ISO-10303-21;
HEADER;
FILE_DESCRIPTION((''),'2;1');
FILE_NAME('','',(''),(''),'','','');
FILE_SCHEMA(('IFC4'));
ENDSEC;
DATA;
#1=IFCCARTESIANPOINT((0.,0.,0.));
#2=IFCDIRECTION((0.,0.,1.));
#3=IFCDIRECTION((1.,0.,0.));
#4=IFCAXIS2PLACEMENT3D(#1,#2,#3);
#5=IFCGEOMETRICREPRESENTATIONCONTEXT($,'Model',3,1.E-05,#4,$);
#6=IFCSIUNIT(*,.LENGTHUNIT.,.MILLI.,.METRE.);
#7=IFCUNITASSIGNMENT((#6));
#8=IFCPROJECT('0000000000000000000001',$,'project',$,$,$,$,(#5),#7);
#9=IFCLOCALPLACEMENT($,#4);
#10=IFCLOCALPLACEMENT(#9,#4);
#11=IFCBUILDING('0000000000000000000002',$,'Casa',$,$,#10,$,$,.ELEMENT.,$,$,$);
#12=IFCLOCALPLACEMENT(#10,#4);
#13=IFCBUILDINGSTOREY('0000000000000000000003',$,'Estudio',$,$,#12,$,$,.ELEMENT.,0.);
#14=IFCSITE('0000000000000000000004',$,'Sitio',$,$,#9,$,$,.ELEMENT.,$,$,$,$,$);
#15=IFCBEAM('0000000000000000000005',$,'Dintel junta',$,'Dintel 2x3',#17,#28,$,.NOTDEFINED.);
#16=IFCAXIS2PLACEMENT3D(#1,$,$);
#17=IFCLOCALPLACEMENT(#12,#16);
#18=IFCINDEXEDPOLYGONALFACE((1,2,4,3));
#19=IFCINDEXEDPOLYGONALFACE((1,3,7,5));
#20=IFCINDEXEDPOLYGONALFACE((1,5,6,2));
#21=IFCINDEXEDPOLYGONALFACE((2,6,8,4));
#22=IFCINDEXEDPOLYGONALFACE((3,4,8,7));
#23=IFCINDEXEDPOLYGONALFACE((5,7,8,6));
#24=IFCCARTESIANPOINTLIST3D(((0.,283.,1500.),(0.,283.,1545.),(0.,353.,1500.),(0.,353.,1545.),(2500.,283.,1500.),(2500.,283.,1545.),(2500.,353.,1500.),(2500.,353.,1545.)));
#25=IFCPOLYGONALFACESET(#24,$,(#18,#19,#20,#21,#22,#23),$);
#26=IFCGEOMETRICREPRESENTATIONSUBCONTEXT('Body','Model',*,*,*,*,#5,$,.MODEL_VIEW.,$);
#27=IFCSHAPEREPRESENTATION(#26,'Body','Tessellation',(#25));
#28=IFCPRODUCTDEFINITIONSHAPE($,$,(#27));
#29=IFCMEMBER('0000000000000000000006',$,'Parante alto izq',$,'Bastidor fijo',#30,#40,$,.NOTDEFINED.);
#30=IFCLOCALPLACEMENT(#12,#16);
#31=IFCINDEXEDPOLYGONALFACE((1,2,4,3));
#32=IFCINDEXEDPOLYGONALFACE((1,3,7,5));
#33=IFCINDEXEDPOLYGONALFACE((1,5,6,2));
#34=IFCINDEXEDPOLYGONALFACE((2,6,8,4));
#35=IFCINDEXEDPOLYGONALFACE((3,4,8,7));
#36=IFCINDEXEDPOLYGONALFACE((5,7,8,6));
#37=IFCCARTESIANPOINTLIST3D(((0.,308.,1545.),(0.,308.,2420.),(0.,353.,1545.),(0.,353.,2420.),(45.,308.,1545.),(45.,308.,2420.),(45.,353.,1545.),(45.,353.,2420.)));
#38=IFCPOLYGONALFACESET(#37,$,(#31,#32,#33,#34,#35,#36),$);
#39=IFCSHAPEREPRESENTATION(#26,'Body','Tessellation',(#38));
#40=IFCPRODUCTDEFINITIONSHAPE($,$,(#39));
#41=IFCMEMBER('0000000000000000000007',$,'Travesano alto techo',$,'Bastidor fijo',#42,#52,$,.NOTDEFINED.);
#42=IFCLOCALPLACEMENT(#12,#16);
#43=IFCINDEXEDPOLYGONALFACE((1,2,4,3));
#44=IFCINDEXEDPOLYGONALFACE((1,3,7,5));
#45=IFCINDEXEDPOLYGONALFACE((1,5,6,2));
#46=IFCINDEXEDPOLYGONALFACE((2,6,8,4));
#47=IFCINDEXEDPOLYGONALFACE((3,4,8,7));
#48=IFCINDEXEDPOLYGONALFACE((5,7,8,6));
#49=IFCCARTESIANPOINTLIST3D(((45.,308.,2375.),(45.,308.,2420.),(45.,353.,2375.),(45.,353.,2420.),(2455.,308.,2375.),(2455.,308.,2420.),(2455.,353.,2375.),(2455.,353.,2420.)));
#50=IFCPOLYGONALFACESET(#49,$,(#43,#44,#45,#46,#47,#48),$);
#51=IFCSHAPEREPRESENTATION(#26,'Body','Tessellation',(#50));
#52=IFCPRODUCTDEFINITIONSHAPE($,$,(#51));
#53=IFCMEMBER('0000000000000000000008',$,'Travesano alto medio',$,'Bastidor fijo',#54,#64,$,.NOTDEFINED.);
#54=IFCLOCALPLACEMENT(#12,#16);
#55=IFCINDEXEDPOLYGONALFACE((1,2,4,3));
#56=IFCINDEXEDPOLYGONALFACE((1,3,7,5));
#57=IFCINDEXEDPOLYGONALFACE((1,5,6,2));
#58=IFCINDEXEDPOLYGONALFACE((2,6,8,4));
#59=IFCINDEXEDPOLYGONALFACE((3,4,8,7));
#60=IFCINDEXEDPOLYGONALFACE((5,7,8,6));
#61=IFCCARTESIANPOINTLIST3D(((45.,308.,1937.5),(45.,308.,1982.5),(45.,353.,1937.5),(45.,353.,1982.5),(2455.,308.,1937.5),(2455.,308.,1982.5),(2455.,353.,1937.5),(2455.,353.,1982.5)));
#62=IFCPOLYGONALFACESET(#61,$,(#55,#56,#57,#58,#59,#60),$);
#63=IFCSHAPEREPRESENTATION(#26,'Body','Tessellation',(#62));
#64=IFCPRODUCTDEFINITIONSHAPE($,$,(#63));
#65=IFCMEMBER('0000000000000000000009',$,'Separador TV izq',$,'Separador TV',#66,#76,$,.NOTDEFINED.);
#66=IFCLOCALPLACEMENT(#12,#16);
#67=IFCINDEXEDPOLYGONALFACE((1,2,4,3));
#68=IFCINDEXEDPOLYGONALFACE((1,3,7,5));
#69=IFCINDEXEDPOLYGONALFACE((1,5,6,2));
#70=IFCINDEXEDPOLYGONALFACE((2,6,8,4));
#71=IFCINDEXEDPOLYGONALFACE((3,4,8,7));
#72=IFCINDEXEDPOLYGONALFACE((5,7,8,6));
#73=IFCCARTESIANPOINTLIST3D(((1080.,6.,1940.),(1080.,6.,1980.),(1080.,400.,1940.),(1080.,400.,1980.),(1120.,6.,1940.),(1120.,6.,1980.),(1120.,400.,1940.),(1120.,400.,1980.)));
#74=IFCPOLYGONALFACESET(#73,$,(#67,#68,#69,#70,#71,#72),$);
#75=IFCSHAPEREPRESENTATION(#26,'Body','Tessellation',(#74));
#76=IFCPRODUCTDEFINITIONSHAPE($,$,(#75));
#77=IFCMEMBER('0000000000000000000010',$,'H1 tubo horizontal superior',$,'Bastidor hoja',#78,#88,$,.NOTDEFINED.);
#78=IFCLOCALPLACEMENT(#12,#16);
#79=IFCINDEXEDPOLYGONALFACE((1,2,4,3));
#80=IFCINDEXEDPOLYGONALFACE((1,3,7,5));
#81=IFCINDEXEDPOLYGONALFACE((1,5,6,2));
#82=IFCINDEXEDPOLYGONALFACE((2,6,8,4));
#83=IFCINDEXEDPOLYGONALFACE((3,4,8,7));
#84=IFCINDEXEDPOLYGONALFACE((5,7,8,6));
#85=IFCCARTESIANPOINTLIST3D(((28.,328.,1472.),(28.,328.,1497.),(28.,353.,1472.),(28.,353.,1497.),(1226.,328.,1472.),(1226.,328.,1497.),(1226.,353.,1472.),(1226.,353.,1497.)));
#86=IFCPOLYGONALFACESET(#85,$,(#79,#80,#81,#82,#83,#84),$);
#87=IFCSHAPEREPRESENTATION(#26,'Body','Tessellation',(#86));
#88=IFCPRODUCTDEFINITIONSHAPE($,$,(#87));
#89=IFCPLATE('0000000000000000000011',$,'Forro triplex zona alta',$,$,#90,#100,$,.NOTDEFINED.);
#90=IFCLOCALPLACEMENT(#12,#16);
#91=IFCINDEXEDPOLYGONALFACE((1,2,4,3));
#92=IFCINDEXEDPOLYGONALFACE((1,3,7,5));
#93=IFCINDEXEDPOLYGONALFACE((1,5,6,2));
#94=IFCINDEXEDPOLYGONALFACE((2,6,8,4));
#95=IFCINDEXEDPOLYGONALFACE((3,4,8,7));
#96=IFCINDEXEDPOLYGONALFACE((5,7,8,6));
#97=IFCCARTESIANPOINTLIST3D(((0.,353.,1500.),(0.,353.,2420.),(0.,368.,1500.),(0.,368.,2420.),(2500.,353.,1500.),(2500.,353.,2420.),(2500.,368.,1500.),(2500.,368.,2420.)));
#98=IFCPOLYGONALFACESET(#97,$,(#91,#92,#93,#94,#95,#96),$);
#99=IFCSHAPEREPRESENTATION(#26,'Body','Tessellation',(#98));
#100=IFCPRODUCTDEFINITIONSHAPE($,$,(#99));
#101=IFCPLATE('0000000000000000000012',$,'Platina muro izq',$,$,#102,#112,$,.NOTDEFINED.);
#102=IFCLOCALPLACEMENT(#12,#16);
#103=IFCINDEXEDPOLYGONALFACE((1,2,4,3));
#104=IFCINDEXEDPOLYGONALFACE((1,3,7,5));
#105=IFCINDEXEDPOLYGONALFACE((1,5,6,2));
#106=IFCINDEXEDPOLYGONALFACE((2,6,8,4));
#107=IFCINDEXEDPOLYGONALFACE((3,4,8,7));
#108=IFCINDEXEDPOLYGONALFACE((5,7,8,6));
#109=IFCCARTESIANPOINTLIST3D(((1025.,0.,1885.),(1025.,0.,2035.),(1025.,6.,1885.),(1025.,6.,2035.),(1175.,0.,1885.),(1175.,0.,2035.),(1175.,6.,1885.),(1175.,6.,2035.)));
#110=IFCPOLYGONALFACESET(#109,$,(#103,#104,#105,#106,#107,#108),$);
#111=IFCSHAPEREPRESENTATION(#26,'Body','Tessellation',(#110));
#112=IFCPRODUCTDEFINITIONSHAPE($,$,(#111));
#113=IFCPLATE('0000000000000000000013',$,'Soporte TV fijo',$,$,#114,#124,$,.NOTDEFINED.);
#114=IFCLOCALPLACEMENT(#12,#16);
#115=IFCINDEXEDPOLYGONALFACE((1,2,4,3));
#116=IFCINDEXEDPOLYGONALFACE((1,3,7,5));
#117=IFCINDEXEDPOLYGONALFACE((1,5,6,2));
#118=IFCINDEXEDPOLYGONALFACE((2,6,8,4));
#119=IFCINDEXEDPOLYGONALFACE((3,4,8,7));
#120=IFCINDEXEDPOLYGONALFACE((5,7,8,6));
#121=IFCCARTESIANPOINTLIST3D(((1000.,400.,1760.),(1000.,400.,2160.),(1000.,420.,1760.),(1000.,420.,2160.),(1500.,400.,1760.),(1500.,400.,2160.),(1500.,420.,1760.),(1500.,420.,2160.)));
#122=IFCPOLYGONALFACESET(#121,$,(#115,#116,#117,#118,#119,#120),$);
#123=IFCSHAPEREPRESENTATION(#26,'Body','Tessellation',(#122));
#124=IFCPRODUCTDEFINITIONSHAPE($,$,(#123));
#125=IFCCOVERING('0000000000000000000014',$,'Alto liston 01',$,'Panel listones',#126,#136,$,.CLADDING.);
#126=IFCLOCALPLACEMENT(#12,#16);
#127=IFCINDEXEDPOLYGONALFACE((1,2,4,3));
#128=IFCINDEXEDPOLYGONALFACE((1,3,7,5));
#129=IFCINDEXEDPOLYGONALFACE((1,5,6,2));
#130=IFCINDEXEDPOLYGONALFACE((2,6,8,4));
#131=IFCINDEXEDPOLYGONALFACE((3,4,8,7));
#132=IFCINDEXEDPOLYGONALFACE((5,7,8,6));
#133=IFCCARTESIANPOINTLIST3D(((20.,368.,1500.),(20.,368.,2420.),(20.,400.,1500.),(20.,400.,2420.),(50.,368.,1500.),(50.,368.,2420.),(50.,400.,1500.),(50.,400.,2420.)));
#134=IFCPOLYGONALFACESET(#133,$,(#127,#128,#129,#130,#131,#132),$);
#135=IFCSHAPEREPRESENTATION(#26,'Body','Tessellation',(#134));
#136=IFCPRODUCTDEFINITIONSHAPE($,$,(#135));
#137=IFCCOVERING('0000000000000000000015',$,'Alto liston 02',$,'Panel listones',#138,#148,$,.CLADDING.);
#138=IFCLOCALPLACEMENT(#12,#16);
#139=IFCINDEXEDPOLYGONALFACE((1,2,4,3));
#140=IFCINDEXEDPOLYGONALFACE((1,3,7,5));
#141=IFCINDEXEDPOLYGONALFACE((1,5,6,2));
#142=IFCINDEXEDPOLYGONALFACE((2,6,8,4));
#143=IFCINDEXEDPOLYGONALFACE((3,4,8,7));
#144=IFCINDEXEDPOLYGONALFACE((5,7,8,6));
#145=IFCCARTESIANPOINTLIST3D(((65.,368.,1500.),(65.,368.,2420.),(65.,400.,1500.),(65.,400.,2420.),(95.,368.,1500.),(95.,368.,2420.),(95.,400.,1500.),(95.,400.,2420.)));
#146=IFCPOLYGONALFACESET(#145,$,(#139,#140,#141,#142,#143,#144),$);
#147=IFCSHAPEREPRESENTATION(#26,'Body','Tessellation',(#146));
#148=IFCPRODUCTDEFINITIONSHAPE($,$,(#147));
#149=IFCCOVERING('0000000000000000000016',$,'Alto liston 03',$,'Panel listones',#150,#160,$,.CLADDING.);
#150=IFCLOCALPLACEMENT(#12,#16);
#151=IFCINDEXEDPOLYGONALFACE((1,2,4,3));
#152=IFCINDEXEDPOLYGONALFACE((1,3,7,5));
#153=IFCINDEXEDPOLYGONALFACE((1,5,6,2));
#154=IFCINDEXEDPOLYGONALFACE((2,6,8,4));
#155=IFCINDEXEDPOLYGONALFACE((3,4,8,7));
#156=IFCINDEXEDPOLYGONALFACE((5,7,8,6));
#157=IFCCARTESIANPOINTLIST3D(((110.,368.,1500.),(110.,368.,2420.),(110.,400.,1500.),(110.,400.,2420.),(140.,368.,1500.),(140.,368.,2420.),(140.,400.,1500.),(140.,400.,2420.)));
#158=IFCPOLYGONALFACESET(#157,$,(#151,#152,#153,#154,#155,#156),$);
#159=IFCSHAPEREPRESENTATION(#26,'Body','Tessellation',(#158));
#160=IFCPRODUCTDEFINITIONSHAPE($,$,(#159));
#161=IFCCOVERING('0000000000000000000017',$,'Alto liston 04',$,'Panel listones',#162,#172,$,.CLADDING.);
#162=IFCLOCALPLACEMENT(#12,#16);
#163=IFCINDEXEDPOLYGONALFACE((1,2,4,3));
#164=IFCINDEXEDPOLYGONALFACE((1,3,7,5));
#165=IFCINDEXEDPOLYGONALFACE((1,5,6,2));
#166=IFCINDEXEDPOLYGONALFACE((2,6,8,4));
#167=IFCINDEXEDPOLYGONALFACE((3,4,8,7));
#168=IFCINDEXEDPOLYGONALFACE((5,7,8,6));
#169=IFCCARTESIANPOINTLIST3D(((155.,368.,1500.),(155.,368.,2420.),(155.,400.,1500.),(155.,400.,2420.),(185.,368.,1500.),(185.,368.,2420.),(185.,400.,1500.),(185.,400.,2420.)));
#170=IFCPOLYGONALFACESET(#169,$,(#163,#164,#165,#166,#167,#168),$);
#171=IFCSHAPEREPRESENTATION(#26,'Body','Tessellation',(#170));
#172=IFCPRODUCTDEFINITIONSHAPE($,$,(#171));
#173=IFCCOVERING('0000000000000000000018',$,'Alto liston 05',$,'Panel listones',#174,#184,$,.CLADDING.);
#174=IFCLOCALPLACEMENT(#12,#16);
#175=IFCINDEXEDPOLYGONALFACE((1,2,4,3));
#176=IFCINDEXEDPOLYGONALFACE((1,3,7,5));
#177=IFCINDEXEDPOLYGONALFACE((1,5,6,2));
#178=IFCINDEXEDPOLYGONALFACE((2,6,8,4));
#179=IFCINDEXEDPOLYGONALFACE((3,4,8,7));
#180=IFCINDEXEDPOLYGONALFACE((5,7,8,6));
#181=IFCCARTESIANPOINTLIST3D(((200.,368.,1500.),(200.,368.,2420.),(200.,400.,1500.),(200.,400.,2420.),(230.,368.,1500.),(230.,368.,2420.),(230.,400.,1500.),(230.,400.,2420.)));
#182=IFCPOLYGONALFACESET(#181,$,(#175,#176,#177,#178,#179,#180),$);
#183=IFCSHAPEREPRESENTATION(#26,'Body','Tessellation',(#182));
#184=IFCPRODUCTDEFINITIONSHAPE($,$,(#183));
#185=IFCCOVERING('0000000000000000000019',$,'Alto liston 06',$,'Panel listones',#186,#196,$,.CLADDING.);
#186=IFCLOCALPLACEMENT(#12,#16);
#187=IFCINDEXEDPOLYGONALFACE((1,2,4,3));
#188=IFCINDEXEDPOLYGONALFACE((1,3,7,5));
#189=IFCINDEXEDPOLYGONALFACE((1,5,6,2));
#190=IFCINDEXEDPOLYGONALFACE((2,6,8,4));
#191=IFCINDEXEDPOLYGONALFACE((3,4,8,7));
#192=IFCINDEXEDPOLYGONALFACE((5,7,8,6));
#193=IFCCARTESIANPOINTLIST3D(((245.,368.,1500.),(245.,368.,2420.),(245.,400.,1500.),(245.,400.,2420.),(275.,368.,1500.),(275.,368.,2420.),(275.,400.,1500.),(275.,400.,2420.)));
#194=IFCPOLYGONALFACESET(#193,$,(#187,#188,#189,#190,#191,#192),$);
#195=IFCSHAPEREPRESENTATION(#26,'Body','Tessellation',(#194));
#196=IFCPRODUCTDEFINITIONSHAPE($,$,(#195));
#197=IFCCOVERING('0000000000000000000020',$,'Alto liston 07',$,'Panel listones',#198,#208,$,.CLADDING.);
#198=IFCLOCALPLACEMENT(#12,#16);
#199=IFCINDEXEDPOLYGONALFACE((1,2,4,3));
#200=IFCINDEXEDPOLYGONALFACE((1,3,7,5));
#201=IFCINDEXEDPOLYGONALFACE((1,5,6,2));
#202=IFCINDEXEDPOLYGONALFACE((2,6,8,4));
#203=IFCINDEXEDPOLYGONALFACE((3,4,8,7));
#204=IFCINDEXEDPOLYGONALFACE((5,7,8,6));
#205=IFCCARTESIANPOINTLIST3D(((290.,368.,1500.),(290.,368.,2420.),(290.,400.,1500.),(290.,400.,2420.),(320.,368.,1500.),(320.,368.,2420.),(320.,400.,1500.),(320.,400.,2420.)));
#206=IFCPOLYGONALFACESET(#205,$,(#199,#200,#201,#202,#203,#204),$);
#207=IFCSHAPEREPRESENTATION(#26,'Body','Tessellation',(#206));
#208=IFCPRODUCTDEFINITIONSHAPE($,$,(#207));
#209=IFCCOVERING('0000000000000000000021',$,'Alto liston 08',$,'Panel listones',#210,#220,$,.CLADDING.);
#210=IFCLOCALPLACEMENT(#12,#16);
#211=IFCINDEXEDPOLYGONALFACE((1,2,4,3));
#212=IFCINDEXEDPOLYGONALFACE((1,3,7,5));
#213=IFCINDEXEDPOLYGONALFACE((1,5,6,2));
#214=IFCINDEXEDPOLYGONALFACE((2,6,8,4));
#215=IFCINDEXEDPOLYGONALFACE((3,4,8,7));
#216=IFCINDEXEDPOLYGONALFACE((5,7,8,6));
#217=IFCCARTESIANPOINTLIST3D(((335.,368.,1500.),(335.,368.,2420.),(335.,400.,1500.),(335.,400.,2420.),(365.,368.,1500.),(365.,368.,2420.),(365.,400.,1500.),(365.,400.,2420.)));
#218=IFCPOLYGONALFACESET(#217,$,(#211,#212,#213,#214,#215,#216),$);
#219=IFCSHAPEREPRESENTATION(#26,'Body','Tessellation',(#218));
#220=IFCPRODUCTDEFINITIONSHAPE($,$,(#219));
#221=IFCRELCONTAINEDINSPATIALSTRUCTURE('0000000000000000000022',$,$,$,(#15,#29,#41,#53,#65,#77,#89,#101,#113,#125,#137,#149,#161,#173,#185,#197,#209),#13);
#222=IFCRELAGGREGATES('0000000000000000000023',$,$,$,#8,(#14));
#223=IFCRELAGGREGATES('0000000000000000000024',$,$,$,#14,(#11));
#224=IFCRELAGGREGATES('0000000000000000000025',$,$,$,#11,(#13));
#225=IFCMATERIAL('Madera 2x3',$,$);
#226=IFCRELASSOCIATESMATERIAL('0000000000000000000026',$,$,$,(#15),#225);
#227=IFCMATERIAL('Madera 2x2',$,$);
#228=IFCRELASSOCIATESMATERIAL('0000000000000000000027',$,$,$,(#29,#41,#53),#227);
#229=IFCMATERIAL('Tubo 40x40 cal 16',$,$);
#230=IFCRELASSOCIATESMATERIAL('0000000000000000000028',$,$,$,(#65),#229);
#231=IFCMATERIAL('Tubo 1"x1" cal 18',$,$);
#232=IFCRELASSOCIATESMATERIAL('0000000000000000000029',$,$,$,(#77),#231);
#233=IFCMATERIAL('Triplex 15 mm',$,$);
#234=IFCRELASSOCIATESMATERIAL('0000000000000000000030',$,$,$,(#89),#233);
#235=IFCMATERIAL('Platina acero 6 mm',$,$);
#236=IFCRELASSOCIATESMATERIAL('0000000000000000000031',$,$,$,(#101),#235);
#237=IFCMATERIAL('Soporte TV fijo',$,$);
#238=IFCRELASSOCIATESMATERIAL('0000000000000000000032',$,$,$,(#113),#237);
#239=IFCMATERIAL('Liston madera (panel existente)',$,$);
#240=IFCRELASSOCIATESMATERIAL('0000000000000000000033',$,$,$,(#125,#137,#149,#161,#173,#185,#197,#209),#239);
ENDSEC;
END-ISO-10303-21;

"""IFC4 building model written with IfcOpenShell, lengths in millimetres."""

from ifc_helpers import new_model, si_unit, frame, frame_2d, origin_with_axes, place, context, subcontext, project, spatial, rectangle, extrude, material, element, save


model = new_model("IFC4")

# Units and contexts
model_context = context("Model", 3, precision=1e-05, world=origin_with_axes())
body_context = subcontext(model_context, "Body", "Model", "MODEL_VIEW")
ifc_project = project(units=[si_unit("LENGTHUNIT", "METRE", prefix="MILLI")], contexts=[model_context])

# Site, building, storey
site_placement = place(None, origin_with_axes())
site = spatial("IfcSite", under=ifc_project, at=site_placement, Name="Sitio", CompositionType="ELEMENT")
building_placement = place(site_placement, origin_with_axes())
building = spatial("IfcBuilding", under=site, at=building_placement, Name="Casa", CompositionType="ELEMENT")
storey_placement = place(building_placement, origin_with_axes())
storey = spatial("IfcBuildingStorey", under=building, at=storey_placement, Name="Estudio", CompositionType="ELEMENT", Elevation=0.0)

# Beam
ifc_material_1 = material(Name="Madera 2x3")
beam_placement = place(storey_placement, frame((0.0, 283.0, 1500.0), z_axis=(0.0, 0.0, 1.0), x_axis=(1.0, 0.0, 0.0)))
element("IfcBeam", 1, at=beam_placement, inside=storey, material=ifc_material_1, Name="Dintel junta", ObjectType="Dintel 2x3", PredefinedType="NOTDEFINED", context=body_context, shape_type="SweptSolid", body=[
    extrude(rectangle(XDim=2500.0, YDim=70.0, at=frame_2d((1250.0, 35.0))), origin_with_axes(), (0.0, 0.0, 1.0), 45.0),
])

# Members
ifc_material_2 = material(Name="Madera 2x2")
member_1_placement = place(storey_placement, frame((0.0, 308.0, 1545.0), z_axis=(0.0, 0.0, 1.0), x_axis=(1.0, 0.0, 0.0)))
element("IfcMember", 2, at=member_1_placement, inside=storey, material=ifc_material_2, Name="Parante alto izq", ObjectType="Bastidor fijo", PredefinedType="NOTDEFINED", context=body_context, shape_type="SweptSolid", body=[
    extrude(rectangle(XDim=45.0, YDim=45.0, at=frame_2d((22.5, 22.5))), origin_with_axes(), (0.0, 0.0, 1.0), 875.0),
])
for number, where, z_axis, x_axis, name in (
    (3, (45.0, 308.0, 2375.0), (0.0, 0.0, 1.0), (1.0, 0.0, 0.0), "Travesano alto techo"),
    (4, (45.0, 308.0, 1937.5), (0.0, 0.0, 1.0), (1.0, 0.0, 0.0), "Travesano alto medio"),
):
    element("IfcMember", number, at=place(storey_placement, frame(where, z_axis=z_axis, x_axis=x_axis)), inside=storey, material=ifc_material_2, Name=name, ObjectType="Bastidor fijo", PredefinedType="NOTDEFINED", context=body_context, shape_type="SweptSolid", body=[
        extrude(rectangle(XDim=2410.0, YDim=45.0, at=frame_2d((1205.0, 22.5))), origin_with_axes(), (0.0, 0.0, 1.0), 45.0),
    ])
ifc_material_3 = material(Name="Tubo 40x40 cal 16")
member_2_placement = place(storey_placement, frame((1080.0, 6.0, 1940.0), z_axis=(0.0, 0.0, 1.0), x_axis=(1.0, 0.0, 0.0)))
element("IfcMember", 5, at=member_2_placement, inside=storey, material=ifc_material_3, Name="Separador TV izq", ObjectType="Separador TV", PredefinedType="NOTDEFINED", context=body_context, shape_type="SweptSolid", body=[
    extrude(rectangle(XDim=40.0, YDim=394.0, at=frame_2d((20.0, 197.0))), origin_with_axes(), (0.0, 0.0, 1.0), 40.0),
])
ifc_material_4 = material(Name="Tubo 1\"x1\" cal 18")
member_3_placement = place(storey_placement, frame((28.0, 328.0, 1472.0), z_axis=(0.0, 0.0, 1.0), x_axis=(1.0, 0.0, 0.0)))
element("IfcMember", 6, at=member_3_placement, inside=storey, material=ifc_material_4, Name="H1 tubo horizontal superior", ObjectType="Bastidor hoja", PredefinedType="NOTDEFINED", context=body_context, shape_type="SweptSolid", body=[
    extrude(rectangle(XDim=1198.0, YDim=25.0, at=frame_2d((599.0, 12.5))), origin_with_axes(), (0.0, 0.0, 1.0), 25.0),
])

# Plates
ifc_material_5 = material(Name="Triplex 15 mm")
plate_1_placement = place(storey_placement, frame((0.0, 353.0, 1500.0), z_axis=(0.0, 0.0, 1.0), x_axis=(1.0, 0.0, 0.0)))
element("IfcPlate", 7, at=plate_1_placement, inside=storey, material=ifc_material_5, Name="Forro triplex zona alta", PredefinedType="NOTDEFINED", context=body_context, shape_type="SweptSolid", body=[
    extrude(rectangle(XDim=2500.0, YDim=15.0, at=frame_2d((1250.0, 7.5))), origin_with_axes(), (0.0, 0.0, 1.0), 920.0),
])
ifc_material_6 = material(Name="Platina acero 6 mm")
plate_2_placement = place(storey_placement, frame((1025.0, 0.0, 1885.0), z_axis=(0.0, 0.0, 1.0), x_axis=(1.0, 0.0, 0.0)))
element("IfcPlate", 8, at=plate_2_placement, inside=storey, material=ifc_material_6, Name="Platina muro izq", PredefinedType="NOTDEFINED", context=body_context, shape_type="SweptSolid", body=[
    extrude(rectangle(XDim=150.0, YDim=6.0, at=frame_2d((75.0, 3.0))), origin_with_axes(), (0.0, 0.0, 1.0), 150.0),
])
ifc_material_7 = material(Name="Soporte TV fijo")
plate_3_placement = place(storey_placement, frame((1000.0, 400.0, 1760.0), z_axis=(0.0, 0.0, 1.0), x_axis=(1.0, 0.0, 0.0)))
element("IfcPlate", 9, at=plate_3_placement, inside=storey, material=ifc_material_7, Name="Soporte TV fijo", PredefinedType="NOTDEFINED", context=body_context, shape_type="SweptSolid", body=[
    extrude(rectangle(XDim=500.0, YDim=20.0, at=frame_2d((250.0, 10.0))), origin_with_axes(), (0.0, 0.0, 1.0), 400.0),
])

# Coverings
ifc_material_8 = material(Name="Liston madera (panel existente)")
for number, where, z_axis, x_axis, name in (
    (10, (20.0, 368.0, 1500.0), (0.0, 0.0, 1.0), (1.0, 0.0, 0.0), "Alto liston 01"),
    (11, (65.0, 368.0, 1500.0), (0.0, 0.0, 1.0), (1.0, 0.0, 0.0), "Alto liston 02"),
    (12, (110.0, 368.0, 1500.0), (0.0, 0.0, 1.0), (1.0, 0.0, 0.0), "Alto liston 03"),
    (13, (155.0, 368.0, 1500.0), (0.0, 0.0, 1.0), (1.0, 0.0, 0.0), "Alto liston 04"),
    (14, (200.0, 368.0, 1500.0), (0.0, 0.0, 1.0), (1.0, 0.0, 0.0), "Alto liston 05"),
    (15, (245.0, 368.0, 1500.0), (0.0, 0.0, 1.0), (1.0, 0.0, 0.0), "Alto liston 06"),
    (16, (290.0, 368.0, 1500.0), (0.0, 0.0, 1.0), (1.0, 0.0, 0.0), "Alto liston 07"),
    (17, (335.0, 368.0, 1500.0), (0.0, 0.0, 1.0), (1.0, 0.0, 0.0), "Alto liston 08"),
):
    element("IfcCovering", number, at=place(storey_placement, frame(where, z_axis=z_axis, x_axis=x_axis)), inside=storey, material=ifc_material_8, Name=name, ObjectType="Panel listones", PredefinedType="CLADDING", context=body_context, shape_type="SweptSolid", body=[
        extrude(rectangle(XDim=30.0, YDim=32.0, at=frame_2d((15.0, 16.0))), origin_with_axes(), (0.0, 0.0, 1.0), 920.0),
    ])

save(model, "model.ifc")
